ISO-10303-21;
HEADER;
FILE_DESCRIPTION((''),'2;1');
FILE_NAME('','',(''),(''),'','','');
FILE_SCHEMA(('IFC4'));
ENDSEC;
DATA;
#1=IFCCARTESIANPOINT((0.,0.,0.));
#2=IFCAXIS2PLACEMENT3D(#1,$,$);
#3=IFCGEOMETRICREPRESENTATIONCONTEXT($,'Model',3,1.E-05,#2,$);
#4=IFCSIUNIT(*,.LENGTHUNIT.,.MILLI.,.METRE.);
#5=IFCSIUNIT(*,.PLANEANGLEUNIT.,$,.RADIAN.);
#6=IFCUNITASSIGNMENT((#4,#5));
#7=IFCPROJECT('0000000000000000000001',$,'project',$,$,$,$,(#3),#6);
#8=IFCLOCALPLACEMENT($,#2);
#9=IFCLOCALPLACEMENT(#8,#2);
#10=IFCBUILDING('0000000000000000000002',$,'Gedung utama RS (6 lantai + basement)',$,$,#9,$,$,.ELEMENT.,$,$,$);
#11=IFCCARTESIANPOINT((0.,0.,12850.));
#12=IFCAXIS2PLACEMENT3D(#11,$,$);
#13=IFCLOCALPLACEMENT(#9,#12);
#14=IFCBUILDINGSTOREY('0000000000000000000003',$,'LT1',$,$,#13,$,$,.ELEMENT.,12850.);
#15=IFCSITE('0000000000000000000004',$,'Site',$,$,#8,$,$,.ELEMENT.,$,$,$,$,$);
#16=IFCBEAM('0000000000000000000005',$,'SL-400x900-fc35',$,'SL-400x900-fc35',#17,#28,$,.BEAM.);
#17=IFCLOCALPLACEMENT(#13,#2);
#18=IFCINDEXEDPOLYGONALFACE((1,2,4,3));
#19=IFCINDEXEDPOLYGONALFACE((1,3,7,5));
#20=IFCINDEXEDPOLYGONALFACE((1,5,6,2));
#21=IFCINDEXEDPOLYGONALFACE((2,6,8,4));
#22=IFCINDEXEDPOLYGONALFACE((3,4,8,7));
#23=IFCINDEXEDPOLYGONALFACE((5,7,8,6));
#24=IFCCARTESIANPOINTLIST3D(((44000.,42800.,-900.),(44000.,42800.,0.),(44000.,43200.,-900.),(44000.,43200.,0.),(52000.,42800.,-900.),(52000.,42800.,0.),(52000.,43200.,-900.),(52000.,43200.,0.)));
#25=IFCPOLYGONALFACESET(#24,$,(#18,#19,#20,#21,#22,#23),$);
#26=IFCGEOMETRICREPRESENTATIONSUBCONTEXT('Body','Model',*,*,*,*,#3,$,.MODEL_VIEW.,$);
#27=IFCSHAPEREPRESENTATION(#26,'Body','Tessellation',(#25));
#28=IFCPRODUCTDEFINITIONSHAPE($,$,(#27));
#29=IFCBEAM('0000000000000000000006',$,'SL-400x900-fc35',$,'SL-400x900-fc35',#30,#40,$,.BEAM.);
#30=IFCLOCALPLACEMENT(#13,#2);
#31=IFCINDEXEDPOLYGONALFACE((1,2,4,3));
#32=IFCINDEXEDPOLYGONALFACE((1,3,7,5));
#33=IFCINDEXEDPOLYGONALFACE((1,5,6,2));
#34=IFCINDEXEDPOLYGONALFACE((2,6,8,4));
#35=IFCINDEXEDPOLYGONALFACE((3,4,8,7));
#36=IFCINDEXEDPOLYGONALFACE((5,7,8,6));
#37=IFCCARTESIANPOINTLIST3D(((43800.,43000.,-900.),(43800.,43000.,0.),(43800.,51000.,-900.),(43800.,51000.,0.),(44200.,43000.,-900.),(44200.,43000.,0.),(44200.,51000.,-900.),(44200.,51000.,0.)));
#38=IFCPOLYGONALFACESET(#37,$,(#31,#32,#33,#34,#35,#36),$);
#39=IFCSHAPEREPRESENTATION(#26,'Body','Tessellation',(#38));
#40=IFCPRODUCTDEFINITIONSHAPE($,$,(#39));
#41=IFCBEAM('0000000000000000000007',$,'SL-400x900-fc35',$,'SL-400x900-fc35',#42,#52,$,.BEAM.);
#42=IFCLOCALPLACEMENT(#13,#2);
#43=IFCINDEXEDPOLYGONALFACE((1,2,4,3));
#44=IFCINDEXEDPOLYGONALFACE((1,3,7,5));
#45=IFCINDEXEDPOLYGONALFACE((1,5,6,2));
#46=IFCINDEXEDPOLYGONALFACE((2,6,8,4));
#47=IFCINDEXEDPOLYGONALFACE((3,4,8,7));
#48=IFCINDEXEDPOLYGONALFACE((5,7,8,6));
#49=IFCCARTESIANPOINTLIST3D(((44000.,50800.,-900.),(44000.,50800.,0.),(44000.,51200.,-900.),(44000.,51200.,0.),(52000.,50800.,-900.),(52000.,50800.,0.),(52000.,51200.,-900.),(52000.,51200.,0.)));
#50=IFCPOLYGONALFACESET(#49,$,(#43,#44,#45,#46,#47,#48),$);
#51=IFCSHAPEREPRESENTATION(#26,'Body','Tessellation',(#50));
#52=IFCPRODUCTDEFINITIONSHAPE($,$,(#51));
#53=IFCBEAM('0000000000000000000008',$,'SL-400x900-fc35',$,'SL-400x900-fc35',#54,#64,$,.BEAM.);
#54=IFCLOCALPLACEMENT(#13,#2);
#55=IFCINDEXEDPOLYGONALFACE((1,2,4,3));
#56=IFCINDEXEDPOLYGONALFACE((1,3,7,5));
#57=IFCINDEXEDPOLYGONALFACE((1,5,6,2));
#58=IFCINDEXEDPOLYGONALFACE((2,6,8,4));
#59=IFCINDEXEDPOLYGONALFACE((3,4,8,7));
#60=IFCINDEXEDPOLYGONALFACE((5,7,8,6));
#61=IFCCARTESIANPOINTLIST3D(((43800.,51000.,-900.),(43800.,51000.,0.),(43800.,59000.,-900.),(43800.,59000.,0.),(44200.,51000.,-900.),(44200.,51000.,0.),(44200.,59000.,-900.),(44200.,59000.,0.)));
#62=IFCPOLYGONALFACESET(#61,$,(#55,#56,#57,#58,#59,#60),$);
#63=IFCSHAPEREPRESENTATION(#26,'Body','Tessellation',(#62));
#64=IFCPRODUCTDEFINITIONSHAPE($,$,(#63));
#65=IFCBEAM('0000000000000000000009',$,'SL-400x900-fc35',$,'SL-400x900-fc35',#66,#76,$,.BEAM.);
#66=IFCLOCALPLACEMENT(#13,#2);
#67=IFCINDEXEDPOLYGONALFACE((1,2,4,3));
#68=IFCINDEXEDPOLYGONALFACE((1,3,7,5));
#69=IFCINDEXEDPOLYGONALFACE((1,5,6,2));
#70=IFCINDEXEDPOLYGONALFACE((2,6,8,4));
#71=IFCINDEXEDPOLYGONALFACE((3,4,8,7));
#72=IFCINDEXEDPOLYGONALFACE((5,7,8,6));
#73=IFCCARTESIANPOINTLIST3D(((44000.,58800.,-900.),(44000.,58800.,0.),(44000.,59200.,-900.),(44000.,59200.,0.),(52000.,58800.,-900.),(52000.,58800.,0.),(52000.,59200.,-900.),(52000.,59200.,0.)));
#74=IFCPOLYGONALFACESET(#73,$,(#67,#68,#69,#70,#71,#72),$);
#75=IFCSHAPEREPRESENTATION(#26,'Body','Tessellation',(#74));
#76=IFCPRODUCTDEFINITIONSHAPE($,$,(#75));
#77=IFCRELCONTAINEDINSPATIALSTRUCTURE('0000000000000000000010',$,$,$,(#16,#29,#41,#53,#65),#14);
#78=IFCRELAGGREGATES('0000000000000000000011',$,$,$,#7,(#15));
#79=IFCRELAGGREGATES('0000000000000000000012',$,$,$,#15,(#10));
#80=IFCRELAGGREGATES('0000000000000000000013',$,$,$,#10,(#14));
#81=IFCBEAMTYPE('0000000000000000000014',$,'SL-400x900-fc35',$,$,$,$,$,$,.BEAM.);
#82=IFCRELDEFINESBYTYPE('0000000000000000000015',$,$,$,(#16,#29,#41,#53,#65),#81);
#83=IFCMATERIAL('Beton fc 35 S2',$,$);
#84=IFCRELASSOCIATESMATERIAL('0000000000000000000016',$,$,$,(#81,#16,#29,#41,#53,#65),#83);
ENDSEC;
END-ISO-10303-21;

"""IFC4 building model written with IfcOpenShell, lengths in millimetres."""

from ifc_helpers import new_model, si_unit, frame, origin, origin_2d, place, context, subcontext, project, spatial, rectangle, extrude, material, material_profile, profile_set, profile_usage, type_object, element, save


model = new_model("IFC4")

# Units and contexts
model_context = context("Model", 3, precision=1e-05, world=origin())
body_context = subcontext(model_context, "Body", "Model", "MODEL_VIEW")
ifc_project = project(units=[si_unit("LENGTHUNIT", "METRE", prefix="MILLI"), si_unit("PLANEANGLEUNIT", "RADIAN")], contexts=[model_context])

# Site, building, storey
site_placement = place(None, origin())
site = spatial("IfcSite", under=ifc_project, at=site_placement, Name="Site", CompositionType="ELEMENT")
building_placement = place(site_placement, origin())
building = spatial("IfcBuilding", under=site, at=building_placement, Name="Gedung utama RS (6 lantai + basement)", CompositionType="ELEMENT")
storey_placement = place(building_placement, frame((0.0, 0.0, 12850.0)))
storey = spatial("IfcBuildingStorey", under=building, at=storey_placement, Name="LT1", CompositionType="ELEMENT", Elevation=12850.0)

# Beams
ifc_material = material(Name="Beton fc 35 S2")
ifc_material_profile_1 = material_profile(ifc_material, rectangle(XDim=400.0, YDim=900.0, at=origin_2d()), Name="SL-400x900-fc35")
ifc_profile_set_1 = profile_set([ifc_material_profile_1], Name="SL-400x900-fc35")
ifc_profile_usage_1 = profile_usage(ifc_profile_set_1, cardinal=8)
beam_type = type_object("IfcBeamType", Name="SL-400x900-fc35", PredefinedType="BEAM", material=ifc_profile_set_1)
beam_1_placement = place(storey_placement, frame((44000.0, 43000.0, -450.0)))
element("IfcBeam", 1, at=beam_1_placement, inside=storey, type_object=beam_type, material=ifc_profile_usage_1, Name="SL-400x900-fc35", ObjectType="SL-400x900-fc35", PredefinedType="BEAM", context=body_context, shape_type="SweptSolid", body=[
    extrude(rectangle(XDim=400.0, YDim=900.0, at=origin_2d()), frame((0.0, 0.0, 0.0), z_axis=(1.0, 0.0, 0.0), x_axis=(0.0, 1.0, 0.0)), (0.0, 0.0, 1.0), 8000.0),
])
beam_2_placement = place(storey_placement, frame((44000.0, 43000.0, -450.0)))
element("IfcBeam", 2, at=beam_2_placement, inside=storey, type_object=beam_type, material=ifc_profile_usage_1, Name="SL-400x900-fc35", ObjectType="SL-400x900-fc35", PredefinedType="BEAM", context=body_context, shape_type="SweptSolid", body=[
    extrude(rectangle(XDim=400.0, YDim=900.0, at=origin_2d()), frame((0.0, 0.0, 0.0), z_axis=(0.0, 1.0, 0.0), x_axis=(-1.0, 0.0, 0.0)), (0.0, 0.0, 1.0), 8000.0),
])
beam_3_placement = place(storey_placement, frame((44000.0, 51000.0, -450.0)))
element("IfcBeam", 3, at=beam_3_placement, inside=storey, type_object=beam_type, material=ifc_profile_usage_1, Name="SL-400x900-fc35", ObjectType="SL-400x900-fc35", PredefinedType="BEAM", context=body_context, shape_type="SweptSolid", body=[
    extrude(rectangle(XDim=400.0, YDim=900.0, at=origin_2d()), frame((0.0, 0.0, 0.0), z_axis=(1.0, 0.0, 0.0), x_axis=(0.0, 1.0, 0.0)), (0.0, 0.0, 1.0), 8000.0),
])
beam_4_placement = place(storey_placement, frame((44000.0, 51000.0, -450.0)))
element("IfcBeam", 4, at=beam_4_placement, inside=storey, type_object=beam_type, material=ifc_profile_usage_1, Name="SL-400x900-fc35", ObjectType="SL-400x900-fc35", PredefinedType="BEAM", context=body_context, shape_type="SweptSolid", body=[
    extrude(rectangle(XDim=400.0, YDim=900.0, at=origin_2d()), frame((0.0, 0.0, 0.0), z_axis=(0.0, 1.0, 0.0), x_axis=(-1.0, 0.0, 0.0)), (0.0, 0.0, 1.0), 8000.0),
])
beam_5_placement = place(storey_placement, frame((44000.0, 59000.0, -450.0)))
element("IfcBeam", 5, at=beam_5_placement, inside=storey, type_object=beam_type, material=ifc_profile_usage_1, Name="SL-400x900-fc35", ObjectType="SL-400x900-fc35", PredefinedType="BEAM", context=body_context, shape_type="SweptSolid", body=[
    extrude(rectangle(XDim=400.0, YDim=900.0, at=origin_2d()), frame((0.0, 0.0, 0.0), z_axis=(1.0, 0.0, 0.0), x_axis=(0.0, 1.0, 0.0)), (0.0, 0.0, 1.0), 8000.0),
])

save(model, "model.ifc")
